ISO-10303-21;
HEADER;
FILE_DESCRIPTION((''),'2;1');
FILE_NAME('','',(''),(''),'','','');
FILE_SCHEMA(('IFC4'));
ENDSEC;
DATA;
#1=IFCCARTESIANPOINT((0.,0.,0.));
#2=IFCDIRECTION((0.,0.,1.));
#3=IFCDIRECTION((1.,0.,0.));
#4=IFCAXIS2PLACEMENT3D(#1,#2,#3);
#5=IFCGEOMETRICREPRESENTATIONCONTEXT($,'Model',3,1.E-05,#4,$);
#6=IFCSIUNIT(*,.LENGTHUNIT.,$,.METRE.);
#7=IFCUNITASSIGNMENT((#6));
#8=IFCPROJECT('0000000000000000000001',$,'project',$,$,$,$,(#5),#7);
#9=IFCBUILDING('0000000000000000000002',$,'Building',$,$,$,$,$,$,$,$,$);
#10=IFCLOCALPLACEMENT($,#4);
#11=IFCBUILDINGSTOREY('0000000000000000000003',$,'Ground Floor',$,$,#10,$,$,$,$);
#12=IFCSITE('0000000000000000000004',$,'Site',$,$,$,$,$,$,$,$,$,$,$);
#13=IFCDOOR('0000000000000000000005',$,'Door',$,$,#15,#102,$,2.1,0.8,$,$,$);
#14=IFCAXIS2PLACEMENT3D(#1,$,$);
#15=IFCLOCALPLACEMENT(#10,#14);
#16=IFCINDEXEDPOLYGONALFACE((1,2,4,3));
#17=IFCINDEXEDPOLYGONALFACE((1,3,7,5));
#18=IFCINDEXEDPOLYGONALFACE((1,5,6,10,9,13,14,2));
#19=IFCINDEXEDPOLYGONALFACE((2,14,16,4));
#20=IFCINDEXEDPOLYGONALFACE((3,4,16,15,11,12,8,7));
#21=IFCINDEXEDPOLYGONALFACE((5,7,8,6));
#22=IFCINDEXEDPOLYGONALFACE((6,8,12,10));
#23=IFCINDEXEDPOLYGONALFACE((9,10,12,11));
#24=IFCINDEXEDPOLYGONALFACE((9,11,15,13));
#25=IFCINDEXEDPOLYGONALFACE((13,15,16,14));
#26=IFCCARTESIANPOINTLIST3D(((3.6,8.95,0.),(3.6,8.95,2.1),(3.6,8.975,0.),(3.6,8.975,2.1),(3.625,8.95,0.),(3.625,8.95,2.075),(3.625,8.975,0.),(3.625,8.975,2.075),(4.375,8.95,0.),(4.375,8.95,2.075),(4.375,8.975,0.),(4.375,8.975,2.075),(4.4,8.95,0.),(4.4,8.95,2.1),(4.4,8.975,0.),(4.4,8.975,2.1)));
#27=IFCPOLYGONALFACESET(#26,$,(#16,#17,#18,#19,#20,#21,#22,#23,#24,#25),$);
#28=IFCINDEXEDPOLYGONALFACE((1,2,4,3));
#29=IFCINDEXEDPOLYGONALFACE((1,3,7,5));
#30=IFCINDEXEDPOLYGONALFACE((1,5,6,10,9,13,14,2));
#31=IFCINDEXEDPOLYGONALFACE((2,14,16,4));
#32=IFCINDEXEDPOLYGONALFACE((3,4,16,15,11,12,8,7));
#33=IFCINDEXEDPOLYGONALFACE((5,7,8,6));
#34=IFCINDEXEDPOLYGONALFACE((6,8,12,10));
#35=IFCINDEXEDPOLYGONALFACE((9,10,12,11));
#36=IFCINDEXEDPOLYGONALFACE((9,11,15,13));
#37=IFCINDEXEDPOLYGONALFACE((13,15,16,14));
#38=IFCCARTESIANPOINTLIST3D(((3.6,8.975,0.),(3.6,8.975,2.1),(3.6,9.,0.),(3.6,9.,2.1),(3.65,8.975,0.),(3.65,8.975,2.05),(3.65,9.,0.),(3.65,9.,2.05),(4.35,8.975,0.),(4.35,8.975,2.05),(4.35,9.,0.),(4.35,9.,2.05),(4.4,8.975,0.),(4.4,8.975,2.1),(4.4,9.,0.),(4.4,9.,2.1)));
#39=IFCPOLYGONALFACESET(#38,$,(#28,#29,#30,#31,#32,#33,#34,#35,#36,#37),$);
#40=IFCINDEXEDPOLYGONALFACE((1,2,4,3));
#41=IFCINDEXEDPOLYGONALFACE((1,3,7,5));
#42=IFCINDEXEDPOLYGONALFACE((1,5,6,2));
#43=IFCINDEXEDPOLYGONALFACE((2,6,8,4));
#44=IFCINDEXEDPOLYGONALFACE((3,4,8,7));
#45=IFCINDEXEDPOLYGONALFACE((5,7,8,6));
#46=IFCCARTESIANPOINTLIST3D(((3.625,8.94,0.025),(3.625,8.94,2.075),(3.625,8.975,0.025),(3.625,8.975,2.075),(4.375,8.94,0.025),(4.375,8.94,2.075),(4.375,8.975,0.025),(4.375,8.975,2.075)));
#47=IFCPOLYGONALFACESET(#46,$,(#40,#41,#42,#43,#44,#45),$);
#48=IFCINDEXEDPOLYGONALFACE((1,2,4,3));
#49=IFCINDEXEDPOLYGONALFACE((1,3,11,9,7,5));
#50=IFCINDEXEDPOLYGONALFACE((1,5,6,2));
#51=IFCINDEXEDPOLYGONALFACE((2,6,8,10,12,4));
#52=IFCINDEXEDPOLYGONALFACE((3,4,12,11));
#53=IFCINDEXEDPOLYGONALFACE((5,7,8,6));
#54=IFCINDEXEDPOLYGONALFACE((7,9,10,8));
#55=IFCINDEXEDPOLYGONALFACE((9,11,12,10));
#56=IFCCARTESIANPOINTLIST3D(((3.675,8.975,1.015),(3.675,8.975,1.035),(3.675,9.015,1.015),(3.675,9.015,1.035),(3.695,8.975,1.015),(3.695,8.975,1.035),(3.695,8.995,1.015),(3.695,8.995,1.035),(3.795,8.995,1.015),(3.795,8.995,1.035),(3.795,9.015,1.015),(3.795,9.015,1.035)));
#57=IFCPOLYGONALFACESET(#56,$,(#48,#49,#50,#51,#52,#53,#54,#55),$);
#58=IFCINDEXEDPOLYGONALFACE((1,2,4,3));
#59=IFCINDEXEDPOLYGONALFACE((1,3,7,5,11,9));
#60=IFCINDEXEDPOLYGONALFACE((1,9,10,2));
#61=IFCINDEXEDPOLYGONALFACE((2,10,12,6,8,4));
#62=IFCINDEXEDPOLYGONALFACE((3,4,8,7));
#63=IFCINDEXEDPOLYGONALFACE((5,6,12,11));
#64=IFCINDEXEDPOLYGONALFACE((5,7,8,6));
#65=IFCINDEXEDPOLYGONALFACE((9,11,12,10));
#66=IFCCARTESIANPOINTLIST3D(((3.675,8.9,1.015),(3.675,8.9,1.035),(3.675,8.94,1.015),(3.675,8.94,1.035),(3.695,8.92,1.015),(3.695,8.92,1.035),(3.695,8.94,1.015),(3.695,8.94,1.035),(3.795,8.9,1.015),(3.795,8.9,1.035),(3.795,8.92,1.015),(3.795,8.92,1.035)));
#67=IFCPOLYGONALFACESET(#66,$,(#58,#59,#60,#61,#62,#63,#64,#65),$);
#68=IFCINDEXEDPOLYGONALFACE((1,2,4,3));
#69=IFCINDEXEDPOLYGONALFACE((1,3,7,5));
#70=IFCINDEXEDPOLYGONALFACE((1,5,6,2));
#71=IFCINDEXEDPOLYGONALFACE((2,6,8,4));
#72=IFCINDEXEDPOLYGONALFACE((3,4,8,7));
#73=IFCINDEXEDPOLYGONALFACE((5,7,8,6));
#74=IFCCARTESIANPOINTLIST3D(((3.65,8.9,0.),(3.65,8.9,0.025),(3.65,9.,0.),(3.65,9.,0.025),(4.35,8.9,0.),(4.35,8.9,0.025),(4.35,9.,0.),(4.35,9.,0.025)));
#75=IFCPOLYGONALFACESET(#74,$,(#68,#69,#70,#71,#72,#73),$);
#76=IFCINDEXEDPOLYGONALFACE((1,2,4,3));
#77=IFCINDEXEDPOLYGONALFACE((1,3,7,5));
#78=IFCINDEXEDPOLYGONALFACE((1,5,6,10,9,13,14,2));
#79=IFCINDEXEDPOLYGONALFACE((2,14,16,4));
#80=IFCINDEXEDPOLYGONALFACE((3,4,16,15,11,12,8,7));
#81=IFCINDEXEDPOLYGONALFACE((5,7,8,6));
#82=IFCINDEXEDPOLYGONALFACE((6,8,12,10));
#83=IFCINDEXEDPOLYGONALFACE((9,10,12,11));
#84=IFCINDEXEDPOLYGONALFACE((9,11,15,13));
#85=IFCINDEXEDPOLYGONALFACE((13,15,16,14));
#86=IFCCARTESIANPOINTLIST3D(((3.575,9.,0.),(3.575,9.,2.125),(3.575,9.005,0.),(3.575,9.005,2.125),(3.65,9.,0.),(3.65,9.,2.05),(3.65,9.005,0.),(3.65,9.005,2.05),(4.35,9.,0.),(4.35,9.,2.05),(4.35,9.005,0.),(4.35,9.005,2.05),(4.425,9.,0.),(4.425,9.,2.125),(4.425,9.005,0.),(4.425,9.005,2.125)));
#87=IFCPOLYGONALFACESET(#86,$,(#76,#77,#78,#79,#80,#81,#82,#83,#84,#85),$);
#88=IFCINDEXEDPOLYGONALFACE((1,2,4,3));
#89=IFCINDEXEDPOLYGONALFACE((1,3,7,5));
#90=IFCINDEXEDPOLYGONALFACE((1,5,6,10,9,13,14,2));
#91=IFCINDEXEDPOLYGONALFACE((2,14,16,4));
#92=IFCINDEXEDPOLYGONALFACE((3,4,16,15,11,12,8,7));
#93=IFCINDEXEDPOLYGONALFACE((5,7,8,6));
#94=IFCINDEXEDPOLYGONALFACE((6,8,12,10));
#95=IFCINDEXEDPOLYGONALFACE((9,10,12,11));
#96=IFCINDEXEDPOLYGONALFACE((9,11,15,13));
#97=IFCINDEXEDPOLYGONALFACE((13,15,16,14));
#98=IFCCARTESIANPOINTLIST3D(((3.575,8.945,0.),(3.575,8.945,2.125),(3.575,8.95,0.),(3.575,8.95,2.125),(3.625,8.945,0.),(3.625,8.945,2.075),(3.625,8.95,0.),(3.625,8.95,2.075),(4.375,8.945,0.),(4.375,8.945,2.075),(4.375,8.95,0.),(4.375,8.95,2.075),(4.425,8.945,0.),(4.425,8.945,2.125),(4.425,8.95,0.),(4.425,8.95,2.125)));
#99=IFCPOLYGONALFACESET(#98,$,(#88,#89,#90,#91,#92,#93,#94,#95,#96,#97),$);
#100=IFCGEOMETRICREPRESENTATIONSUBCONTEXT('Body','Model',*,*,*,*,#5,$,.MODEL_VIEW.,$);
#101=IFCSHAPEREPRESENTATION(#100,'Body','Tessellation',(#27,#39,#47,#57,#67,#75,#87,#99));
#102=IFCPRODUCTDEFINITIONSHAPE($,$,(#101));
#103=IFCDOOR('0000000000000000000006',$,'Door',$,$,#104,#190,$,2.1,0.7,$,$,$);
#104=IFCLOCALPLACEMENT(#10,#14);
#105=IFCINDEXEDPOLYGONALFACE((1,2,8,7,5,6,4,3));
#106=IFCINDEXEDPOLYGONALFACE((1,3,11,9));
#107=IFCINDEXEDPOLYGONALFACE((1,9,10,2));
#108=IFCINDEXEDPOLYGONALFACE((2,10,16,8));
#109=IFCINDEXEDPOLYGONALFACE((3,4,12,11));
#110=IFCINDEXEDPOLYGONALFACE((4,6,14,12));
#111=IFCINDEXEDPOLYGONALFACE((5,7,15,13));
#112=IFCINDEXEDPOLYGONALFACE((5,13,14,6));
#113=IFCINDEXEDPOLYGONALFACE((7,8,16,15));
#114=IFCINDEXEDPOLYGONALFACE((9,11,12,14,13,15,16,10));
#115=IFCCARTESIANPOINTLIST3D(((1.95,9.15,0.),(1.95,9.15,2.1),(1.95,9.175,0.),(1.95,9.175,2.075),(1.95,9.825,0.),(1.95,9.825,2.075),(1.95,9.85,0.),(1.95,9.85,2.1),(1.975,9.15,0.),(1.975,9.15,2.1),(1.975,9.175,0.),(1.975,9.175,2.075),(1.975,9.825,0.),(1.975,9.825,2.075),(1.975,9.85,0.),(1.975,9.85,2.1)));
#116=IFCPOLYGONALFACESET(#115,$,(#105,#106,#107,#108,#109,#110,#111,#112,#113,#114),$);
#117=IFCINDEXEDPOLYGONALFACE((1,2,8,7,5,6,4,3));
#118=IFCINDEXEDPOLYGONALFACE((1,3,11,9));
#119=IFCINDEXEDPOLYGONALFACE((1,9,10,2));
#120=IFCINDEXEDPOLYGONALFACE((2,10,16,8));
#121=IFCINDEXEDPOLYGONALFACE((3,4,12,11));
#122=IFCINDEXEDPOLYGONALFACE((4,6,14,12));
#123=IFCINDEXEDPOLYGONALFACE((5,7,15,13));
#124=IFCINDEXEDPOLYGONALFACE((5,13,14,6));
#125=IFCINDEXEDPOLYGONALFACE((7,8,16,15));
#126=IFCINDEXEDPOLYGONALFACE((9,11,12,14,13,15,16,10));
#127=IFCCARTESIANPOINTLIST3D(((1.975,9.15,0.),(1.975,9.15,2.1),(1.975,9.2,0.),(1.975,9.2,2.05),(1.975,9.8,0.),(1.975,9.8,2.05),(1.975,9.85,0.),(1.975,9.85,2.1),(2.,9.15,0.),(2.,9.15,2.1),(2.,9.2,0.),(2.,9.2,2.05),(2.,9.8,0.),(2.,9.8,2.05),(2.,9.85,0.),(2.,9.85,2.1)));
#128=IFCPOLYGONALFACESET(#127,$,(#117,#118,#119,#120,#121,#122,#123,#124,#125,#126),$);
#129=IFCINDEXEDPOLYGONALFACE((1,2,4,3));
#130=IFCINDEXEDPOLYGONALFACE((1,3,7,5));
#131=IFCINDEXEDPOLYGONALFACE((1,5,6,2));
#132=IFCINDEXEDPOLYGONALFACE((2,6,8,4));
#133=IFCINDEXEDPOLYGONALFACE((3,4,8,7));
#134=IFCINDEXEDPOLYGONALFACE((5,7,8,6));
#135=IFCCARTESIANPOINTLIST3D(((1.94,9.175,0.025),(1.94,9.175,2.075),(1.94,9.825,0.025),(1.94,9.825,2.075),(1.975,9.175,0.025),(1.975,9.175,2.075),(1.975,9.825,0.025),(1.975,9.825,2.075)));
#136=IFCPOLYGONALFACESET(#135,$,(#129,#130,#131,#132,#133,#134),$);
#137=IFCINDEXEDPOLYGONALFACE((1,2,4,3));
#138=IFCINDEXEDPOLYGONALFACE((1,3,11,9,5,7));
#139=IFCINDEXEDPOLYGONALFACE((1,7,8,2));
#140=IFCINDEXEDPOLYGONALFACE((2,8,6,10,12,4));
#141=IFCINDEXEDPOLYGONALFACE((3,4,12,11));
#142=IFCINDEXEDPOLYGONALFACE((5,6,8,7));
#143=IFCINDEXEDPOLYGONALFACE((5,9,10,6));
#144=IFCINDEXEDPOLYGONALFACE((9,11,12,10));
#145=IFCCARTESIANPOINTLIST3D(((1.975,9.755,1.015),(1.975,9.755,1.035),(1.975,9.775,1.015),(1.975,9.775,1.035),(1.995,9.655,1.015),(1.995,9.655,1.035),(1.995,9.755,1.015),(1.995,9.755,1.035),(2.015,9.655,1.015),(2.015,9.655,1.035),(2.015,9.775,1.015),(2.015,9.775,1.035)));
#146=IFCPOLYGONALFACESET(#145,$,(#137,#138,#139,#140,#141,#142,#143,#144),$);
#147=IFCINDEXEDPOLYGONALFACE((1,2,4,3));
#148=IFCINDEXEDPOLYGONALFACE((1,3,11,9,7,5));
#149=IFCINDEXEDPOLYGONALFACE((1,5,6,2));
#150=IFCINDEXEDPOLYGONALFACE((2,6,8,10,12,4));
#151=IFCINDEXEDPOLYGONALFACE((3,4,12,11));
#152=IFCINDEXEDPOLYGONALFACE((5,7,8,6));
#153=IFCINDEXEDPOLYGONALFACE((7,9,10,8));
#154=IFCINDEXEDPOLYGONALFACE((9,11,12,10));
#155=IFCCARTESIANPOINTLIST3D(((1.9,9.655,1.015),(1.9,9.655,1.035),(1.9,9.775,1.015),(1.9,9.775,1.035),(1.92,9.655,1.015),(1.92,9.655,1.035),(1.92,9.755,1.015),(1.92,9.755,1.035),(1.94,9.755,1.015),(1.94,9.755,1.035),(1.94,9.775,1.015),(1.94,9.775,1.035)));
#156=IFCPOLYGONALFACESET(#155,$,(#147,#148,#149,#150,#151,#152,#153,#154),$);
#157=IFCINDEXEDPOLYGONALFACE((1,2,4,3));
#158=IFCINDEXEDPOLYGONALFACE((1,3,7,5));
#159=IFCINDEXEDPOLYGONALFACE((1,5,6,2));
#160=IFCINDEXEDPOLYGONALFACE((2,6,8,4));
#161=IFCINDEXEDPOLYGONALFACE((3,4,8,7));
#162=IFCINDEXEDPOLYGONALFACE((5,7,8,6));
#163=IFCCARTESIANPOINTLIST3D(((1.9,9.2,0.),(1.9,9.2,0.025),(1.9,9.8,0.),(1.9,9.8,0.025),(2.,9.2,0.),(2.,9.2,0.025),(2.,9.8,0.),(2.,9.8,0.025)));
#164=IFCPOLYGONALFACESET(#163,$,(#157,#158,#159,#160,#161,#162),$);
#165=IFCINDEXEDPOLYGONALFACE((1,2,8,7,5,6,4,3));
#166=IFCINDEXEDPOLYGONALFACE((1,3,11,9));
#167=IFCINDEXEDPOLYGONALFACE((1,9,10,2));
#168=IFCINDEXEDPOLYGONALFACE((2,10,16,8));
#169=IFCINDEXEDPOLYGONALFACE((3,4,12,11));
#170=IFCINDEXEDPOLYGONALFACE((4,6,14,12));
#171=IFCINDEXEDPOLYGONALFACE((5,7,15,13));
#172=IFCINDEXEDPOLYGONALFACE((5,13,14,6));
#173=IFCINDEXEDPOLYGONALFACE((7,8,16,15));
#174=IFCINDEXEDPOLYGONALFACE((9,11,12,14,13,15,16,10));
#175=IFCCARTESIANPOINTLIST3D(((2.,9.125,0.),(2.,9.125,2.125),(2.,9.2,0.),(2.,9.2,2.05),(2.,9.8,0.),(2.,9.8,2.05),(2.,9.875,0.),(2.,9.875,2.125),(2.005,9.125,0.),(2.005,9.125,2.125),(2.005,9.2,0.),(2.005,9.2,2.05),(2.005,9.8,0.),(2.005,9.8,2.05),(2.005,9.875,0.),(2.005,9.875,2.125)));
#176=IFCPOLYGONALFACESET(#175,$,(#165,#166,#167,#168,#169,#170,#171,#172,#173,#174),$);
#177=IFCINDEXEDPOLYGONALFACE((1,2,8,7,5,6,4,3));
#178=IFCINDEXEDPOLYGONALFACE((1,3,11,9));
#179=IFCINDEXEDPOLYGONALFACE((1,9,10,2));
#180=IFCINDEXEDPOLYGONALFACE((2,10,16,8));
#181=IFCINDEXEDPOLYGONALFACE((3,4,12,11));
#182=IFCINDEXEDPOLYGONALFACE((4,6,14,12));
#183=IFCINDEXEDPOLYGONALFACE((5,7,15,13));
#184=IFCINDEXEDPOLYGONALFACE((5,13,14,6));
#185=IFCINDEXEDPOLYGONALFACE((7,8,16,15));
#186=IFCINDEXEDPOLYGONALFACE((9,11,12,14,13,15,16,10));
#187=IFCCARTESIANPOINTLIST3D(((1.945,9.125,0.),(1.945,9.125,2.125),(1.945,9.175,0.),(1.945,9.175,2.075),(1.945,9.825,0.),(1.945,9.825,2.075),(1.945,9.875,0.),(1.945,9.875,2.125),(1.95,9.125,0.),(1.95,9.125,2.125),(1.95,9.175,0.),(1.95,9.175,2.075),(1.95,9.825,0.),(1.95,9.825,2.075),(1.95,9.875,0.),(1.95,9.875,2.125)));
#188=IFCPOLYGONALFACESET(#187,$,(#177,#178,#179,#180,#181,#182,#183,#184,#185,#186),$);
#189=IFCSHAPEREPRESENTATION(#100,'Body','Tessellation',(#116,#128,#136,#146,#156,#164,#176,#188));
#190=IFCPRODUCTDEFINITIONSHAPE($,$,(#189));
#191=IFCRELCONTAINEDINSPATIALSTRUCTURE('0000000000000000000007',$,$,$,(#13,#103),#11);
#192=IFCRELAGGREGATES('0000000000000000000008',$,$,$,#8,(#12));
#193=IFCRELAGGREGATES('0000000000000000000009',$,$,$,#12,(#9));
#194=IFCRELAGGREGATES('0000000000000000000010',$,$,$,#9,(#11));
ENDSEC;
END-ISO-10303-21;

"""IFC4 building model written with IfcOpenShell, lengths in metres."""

from ifc_helpers import new_model, si_unit, frame, origin_with_axes, place, context, subcontext, project, spatial, line, indexed_curve, outline, extrude, element, save


model = new_model("IFC4")

# Units and contexts
model_context = context("Model", 3, precision=1e-05, world=origin_with_axes())
body_context = subcontext(model_context, "Body", "Model", "MODEL_VIEW")
ifc_project = project(units=[si_unit("LENGTHUNIT", "METRE")], contexts=[model_context])

# Site, building, storey
site = spatial("IfcSite", under=ifc_project, Name="Site")
building = spatial("IfcBuilding", under=site, Name="Building")
storey_placement = place(None, origin_with_axes())
storey = spatial("IfcBuildingStorey", under=building, at=storey_placement, Name="Ground Floor")

# Doors
door_1_placement = place(storey_placement, frame((4.4, 9.0, 0.0), z_axis=(0.0, 0.0, 1.0), x_axis=(-1.0, 0.0, 0.0)))
element("IfcDoor", 1, at=door_1_placement, inside=storey, Name="Door", OverallHeight=2.1, OverallWidth=0.8, context=body_context, shape_type="SweptSolid", body=[
    extrude(outline(indexed_curve([(0.0, 0.0), (0.0, 2.1), (0.8, 2.1), (0.8, 0.0), (0.775, 0.0), (0.775, 2.075), (0.025, 2.075), (0.025, 0.0)], segments=[line(1, 2, 3, 4, 5, 6, 7, 8, 1)])), frame((0.0, 0.025, 0.0), z_axis=(0.0, -1.0, 0.0), x_axis=(1.0, 0.0, 0.0)), (0.0, 0.0, -1.0), 0.025),
    extrude(outline(indexed_curve([(0.0, 0.0), (0.0, 2.1), (0.8, 2.1), (0.8, 0.0), (0.75, 0.0), (0.75, 2.05), (0.05, 2.05), (0.05, 0.0)], segments=[line(1, 2, 3, 4, 5, 6, 7, 8, 1)])), frame((0.0, 0.0, 0.0), z_axis=(0.0, -1.0, 0.0), x_axis=(1.0, 0.0, 0.0)), (0.0, 0.0, -1.0), 0.025),
    extrude(outline(indexed_curve([(0.0, 0.0), (0.75, 0.0), (0.75, 0.035), (0.0, 0.035)], segments=[line(1, 2, 3, 4, 1)])), frame((0.025, 0.025, 0.025), z_axis=(0.0, 0.0, 1.0), x_axis=(1.0, 0.0, 0.0)), (0.0, 0.0, 1.0), 2.05),
    extrude(outline(indexed_curve([(0.0, 0.0), (0.0, -0.04), (-0.12, -0.04), (-0.12, -0.02), (-0.02, -0.02), (-0.02, 0.0)], segments=[line(1, 2, 3, 4, 5, 6, 1)])), frame((0.725, 0.025, 1.015), z_axis=(0.0, 0.0, 1.0), x_axis=(1.0, 0.0, 0.0)), (0.0, 0.0, 1.0), 0.02),
    extrude(outline(indexed_curve([(0.0, 0.0), (0.0, 0.04), (-0.12, 0.04), (-0.12, 0.02), (-0.02, 0.02), (-0.02, 0.0)], segments=[line(1, 2, 3, 4, 5, 6, 1)])), frame((0.725, 0.06, 1.015), z_axis=(0.0, 0.0, 1.0), x_axis=(1.0, 0.0, 0.0)), (0.0, 0.0, 1.0), 0.02),
    extrude(outline(indexed_curve([(0.0, 0.0), (0.7, 0.0), (0.7, 0.1), (0.0, 0.1)], segments=[line(1, 2, 3, 4, 1)])), frame((0.05, 0.0, 0.0), z_axis=(0.0, 0.0, 1.0), x_axis=(1.0, 0.0, 0.0)), (0.0, 0.0, 1.0), 0.025),
    extrude(outline(indexed_curve([(0.0, 0.0), (0.0, 2.125), (0.85, 2.125), (0.85, 0.0), (0.775, 0.0), (0.775, 2.05), (0.075, 2.05), (0.075, 0.0)], segments=[line(1, 2, 3, 4, 5, 6, 7, 8, 1)])), frame((-0.025, -0.005, 0.0), z_axis=(0.0, -1.0, 0.0), x_axis=(1.0, 0.0, 0.0)), (0.0, 0.0, -1.0), 0.005),
    extrude(outline(indexed_curve([(0.0, 0.0), (0.0, 2.125), (0.85, 2.125), (0.85, 0.0), (0.8, 0.0), (0.8, 2.075), (0.05, 2.075), (0.05, 0.0)], segments=[line(1, 2, 3, 4, 5, 6, 7, 8, 1)])), frame((-0.025, 0.05, 0.0), z_axis=(0.0, -1.0, 0.0), x_axis=(1.0, 0.0, 0.0)), (0.0, 0.0, -1.0), 0.005),
])
door_2_placement = place(storey_placement, frame((2.0, 9.15, 0.0), z_axis=(0.0, 0.0, 1.0), x_axis=(0.0, 1.0, 0.0)))
element("IfcDoor", 2, at=door_2_placement, inside=storey, Name="Door", OverallHeight=2.1, OverallWidth=0.7, context=body_context, shape_type="SweptSolid", body=[
    extrude(outline(indexed_curve([(0.0, 0.0), (0.0, 2.1), (0.7, 2.1), (0.7, 0.0), (0.675, 0.0), (0.675, 2.075), (0.025, 2.075), (0.025, 0.0)], segments=[line(1, 2, 3, 4, 5, 6, 7, 8, 1)])), frame((0.0, 0.025, 0.0), z_axis=(0.0, -1.0, 0.0), x_axis=(1.0, 0.0, 0.0)), (0.0, 0.0, -1.0), 0.025),
    extrude(outline(indexed_curve([(0.0, 0.0), (0.0, 2.1), (0.7, 2.1), (0.7, 0.0), (0.65, 0.0), (0.65, 2.05), (0.05, 2.05), (0.05, 0.0)], segments=[line(1, 2, 3, 4, 5, 6, 7, 8, 1)])), frame((0.0, 0.0, 0.0), z_axis=(0.0, -1.0, 0.0), x_axis=(1.0, 0.0, 0.0)), (0.0, 0.0, -1.0), 0.025),
    extrude(outline(indexed_curve([(0.0, 0.0), (0.65, 0.0), (0.65, 0.035), (0.0, 0.035)], segments=[line(1, 2, 3, 4, 1)])), frame((0.025, 0.025, 0.025), z_axis=(0.0, 0.0, 1.0), x_axis=(1.0, 0.0, 0.0)), (0.0, 0.0, 1.0), 2.05),
    extrude(outline(indexed_curve([(0.0, 0.0), (0.0, -0.04), (-0.12, -0.04), (-0.12, -0.02), (-0.02, -0.02), (-0.02, 0.0)], segments=[line(1, 2, 3, 4, 5, 6, 1)])), frame((0.625, 0.025, 1.015), z_axis=(0.0, 0.0, 1.0), x_axis=(1.0, 0.0, 0.0)), (0.0, 0.0, 1.0), 0.02),
    extrude(outline(indexed_curve([(0.0, 0.0), (0.0, 0.04), (-0.12, 0.04), (-0.12, 0.02), (-0.02, 0.02), (-0.02, 0.0)], segments=[line(1, 2, 3, 4, 5, 6, 1)])), frame((0.625, 0.06, 1.015), z_axis=(0.0, 0.0, 1.0), x_axis=(1.0, 0.0, 0.0)), (0.0, 0.0, 1.0), 0.02),
    extrude(outline(indexed_curve([(0.0, 0.0), (0.6, 0.0), (0.6, 0.1), (0.0, 0.1)], segments=[line(1, 2, 3, 4, 1)])), frame((0.05, 0.0, 0.0), z_axis=(0.0, 0.0, 1.0), x_axis=(1.0, 0.0, 0.0)), (0.0, 0.0, 1.0), 0.025),
    extrude(outline(indexed_curve([(0.0, 0.0), (0.0, 2.125), (0.75, 2.125), (0.75, 0.0), (0.675, 0.0), (0.675, 2.05), (0.075, 2.05), (0.075, 0.0)], segments=[line(1, 2, 3, 4, 5, 6, 7, 8, 1)])), frame((-0.025, -0.005, 0.0), z_axis=(0.0, -1.0, 0.0), x_axis=(1.0, 0.0, 0.0)), (0.0, 0.0, -1.0), 0.005),
    extrude(outline(indexed_curve([(0.0, 0.0), (0.0, 2.125), (0.75, 2.125), (0.75, 0.0), (0.7, 0.0), (0.7, 2.075), (0.05, 2.075), (0.05, 0.0)], segments=[line(1, 2, 3, 4, 5, 6, 7, 8, 1)])), frame((-0.025, 0.05, 0.0), z_axis=(0.0, -1.0, 0.0), x_axis=(1.0, 0.0, 0.0)), (0.0, 0.0, -1.0), 0.005),
])

save(model, "model.ifc")
